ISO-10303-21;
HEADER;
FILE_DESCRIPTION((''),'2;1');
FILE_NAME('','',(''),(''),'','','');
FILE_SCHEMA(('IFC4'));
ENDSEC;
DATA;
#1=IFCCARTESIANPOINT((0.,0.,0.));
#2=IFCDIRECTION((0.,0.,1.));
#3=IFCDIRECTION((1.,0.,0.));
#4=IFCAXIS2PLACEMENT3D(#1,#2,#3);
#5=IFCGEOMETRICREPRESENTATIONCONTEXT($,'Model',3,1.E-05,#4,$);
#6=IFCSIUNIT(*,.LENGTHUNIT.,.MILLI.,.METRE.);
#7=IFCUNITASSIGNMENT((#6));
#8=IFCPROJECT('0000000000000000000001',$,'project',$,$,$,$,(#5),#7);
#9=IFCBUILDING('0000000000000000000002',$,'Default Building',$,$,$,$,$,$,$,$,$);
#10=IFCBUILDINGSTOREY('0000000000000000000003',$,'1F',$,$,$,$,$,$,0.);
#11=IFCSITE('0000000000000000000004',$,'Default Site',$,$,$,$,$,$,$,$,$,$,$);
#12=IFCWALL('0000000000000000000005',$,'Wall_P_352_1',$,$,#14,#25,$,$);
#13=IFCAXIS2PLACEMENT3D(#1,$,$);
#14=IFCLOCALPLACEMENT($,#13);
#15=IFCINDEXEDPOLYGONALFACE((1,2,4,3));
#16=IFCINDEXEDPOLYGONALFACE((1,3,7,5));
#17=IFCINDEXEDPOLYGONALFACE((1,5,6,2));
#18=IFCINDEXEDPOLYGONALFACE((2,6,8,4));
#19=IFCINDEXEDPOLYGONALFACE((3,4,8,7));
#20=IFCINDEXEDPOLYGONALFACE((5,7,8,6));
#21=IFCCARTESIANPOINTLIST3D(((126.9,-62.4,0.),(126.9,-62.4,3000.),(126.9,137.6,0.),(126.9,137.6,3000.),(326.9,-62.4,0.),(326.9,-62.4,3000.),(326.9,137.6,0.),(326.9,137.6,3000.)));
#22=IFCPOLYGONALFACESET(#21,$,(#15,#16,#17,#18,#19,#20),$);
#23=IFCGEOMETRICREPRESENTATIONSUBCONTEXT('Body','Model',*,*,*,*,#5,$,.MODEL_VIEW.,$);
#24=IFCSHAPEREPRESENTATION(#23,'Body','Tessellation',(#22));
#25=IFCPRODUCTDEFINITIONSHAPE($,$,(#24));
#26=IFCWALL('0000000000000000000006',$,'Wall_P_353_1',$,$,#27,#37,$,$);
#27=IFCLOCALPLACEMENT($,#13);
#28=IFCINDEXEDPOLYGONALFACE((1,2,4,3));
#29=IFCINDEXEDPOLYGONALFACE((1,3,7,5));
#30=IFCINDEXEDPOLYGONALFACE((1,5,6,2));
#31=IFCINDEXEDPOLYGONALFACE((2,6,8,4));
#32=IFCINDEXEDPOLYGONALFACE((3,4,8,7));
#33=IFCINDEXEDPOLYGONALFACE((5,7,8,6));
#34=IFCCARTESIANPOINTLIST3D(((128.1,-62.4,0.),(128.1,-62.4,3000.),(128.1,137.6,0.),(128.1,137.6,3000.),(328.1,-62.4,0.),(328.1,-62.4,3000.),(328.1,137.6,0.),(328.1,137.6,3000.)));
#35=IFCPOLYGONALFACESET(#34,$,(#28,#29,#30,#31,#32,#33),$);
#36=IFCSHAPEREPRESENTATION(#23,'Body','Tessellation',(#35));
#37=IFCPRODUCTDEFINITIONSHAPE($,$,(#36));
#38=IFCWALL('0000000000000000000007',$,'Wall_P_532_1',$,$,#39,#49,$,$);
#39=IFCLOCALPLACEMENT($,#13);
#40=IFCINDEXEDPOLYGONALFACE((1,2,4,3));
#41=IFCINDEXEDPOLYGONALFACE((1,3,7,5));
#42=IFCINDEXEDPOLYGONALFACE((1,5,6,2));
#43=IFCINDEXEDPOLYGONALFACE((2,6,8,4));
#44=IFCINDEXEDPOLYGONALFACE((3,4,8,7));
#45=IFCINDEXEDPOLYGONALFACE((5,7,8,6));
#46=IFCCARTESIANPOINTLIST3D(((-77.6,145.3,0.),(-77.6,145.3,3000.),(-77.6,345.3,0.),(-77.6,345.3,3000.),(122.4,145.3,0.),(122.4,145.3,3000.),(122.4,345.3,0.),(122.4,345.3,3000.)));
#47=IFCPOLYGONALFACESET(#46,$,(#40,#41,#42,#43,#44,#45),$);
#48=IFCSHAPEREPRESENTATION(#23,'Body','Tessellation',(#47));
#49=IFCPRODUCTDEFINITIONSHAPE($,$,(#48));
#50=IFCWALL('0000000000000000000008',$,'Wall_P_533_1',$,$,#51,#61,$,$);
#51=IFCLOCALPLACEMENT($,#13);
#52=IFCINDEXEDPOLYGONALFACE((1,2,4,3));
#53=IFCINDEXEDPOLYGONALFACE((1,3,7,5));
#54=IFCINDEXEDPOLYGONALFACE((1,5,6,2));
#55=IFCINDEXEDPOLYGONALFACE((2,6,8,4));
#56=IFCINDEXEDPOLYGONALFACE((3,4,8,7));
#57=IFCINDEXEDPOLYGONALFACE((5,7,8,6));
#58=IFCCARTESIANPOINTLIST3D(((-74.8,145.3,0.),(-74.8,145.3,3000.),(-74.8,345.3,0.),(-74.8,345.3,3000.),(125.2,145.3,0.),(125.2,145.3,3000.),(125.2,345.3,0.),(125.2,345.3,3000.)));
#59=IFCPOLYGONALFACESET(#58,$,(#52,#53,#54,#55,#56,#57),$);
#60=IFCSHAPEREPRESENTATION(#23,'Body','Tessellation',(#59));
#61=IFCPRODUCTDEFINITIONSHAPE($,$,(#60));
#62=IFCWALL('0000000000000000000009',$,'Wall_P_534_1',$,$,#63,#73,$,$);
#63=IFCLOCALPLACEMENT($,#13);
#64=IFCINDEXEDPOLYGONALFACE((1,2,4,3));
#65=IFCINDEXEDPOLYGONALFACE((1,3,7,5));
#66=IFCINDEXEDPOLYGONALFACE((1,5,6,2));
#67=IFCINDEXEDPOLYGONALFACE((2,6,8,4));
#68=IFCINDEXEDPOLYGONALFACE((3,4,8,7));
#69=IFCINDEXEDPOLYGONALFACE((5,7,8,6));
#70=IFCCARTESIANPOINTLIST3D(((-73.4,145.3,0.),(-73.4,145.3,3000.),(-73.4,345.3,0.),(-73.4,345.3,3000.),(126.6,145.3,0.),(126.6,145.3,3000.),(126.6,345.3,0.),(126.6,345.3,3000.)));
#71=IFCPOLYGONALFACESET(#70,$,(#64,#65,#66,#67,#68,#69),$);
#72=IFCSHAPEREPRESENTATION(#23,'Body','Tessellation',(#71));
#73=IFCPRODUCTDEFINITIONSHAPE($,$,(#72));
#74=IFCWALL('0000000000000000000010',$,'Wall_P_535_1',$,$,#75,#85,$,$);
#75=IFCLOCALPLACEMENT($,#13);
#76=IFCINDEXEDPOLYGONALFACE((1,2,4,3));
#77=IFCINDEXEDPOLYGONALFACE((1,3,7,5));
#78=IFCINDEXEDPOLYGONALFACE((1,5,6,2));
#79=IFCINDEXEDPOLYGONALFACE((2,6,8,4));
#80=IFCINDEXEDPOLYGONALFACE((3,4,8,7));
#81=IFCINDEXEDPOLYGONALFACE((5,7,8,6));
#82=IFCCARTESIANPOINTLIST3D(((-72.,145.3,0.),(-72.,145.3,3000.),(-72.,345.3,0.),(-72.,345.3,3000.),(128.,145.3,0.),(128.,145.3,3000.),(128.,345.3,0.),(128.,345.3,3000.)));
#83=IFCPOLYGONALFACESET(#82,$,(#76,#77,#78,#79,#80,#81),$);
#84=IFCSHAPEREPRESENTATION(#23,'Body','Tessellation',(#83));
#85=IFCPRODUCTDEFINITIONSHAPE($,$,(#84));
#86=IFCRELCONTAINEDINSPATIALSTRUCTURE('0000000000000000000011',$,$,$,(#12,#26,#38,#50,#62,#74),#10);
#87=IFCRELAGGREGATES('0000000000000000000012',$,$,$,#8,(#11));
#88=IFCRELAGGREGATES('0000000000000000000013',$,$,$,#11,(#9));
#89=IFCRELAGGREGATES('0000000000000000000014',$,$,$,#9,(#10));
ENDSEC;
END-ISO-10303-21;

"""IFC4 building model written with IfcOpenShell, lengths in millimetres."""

from ifc_helpers import new_model, si_unit, frame, origin_with_axes, place, context, subcontext, project, spatial, indexed_curve, outline, extrude, element, save


model = new_model("IFC4")

# Units and contexts
model_context = context("Model", 3, precision=1e-05, world=origin_with_axes())
body_context = subcontext(model_context, "Body", "Model", "MODEL_VIEW")
ifc_project = project(units=[si_unit("LENGTHUNIT", "METRE", prefix="MILLI")], contexts=[model_context])

# Site, building, storey
site = spatial("IfcSite", under=ifc_project, Name="Default Site")
building = spatial("IfcBuilding", under=site, Name="Default Building")
storey = spatial("IfcBuildingStorey", under=building, Name="1F", Elevation=0.0)

# Walls
for number, where, z_axis, x_axis, name in (
    (1, (126.9, 137.6, 0.0), (0.0, 0.0, 1.0), (0.0, -1.0, 0.0), "Wall_P_352_1"),
    (2, (128.1, 137.6, 0.0), (0.0, 0.0, 1.0), (0.0, -1.0, 0.0), "Wall_P_353_1"),
):
    element("IfcWall", number, at=place(None, frame(where, z_axis=z_axis, x_axis=x_axis)), inside=storey, Name=name, context=body_context, shape_type="SweptSolid", body=[
        extrude(outline(indexed_curve([(0.0, 0.0), (0.0, 200.0), (200.0, 200.0), (200.0, 0.0), (0.0, 0.0)], self_intersect=False)), origin_with_axes(), (0.0, 0.0, 1.0), 3000.0),
    ])
wall_1_placement = place(None, frame((122.4, 145.3, 0.0), z_axis=(0.0, 0.0, 1.0), x_axis=(0.0, 1.0, 0.0)))
element("IfcWall", 3, at=wall_1_placement, inside=storey, Name="Wall_P_532_1", context=body_context, shape_type="SweptSolid", body=[
    extrude(outline(indexed_curve([(0.0, 0.0), (0.0, 200.0), (200.0, 200.0), (200.0, 0.0), (0.0, 0.0)], self_intersect=False)), origin_with_axes(), (0.0, 0.0, 1.0), 3000.0),
])
wall_2_placement = place(None, frame((125.2, 145.3, 0.0), z_axis=(0.0, 0.0, 1.0), x_axis=(0.0, 1.0, 0.0)))
element("IfcWall", 4, at=wall_2_placement, inside=storey, Name="Wall_P_533_1", context=body_context, shape_type="SweptSolid", body=[
    extrude(outline(indexed_curve([(0.0, 0.0), (0.0, 200.0), (200.0, 200.0), (200.0, 0.0), (0.0, 0.0)], self_intersect=False)), origin_with_axes(), (0.0, 0.0, 1.0), 3000.0),
])
wall_3_placement = place(None, frame((126.6, 145.3, 0.0), z_axis=(0.0, 0.0, 1.0), x_axis=(0.0, 1.0, 0.0)))
element("IfcWall", 5, at=wall_3_placement, inside=storey, Name="Wall_P_534_1", context=body_context, shape_type="SweptSolid", body=[
    extrude(outline(indexed_curve([(0.0, 0.0), (0.0, 200.0), (200.0, 200.0), (200.0, 0.0), (0.0, 0.0)], self_intersect=False)), origin_with_axes(), (0.0, 0.0, 1.0), 3000.0),
])
wall_4_placement = place(None, frame((128.0, 145.3, 0.0), z_axis=(0.0, 0.0, 1.0), x_axis=(0.0, 1.0, 0.0)))
element("IfcWall", 6, at=wall_4_placement, inside=storey, Name="Wall_P_535_1", context=body_context, shape_type="SweptSolid", body=[
    extrude(outline(indexed_curve([(0.0, 0.0), (0.0, 200.0), (200.0, 200.0), (200.0, 0.0), (0.0, 0.0)], self_intersect=False)), origin_with_axes(), (0.0, 0.0, 1.0), 3000.0),
])

save(model, "model.ifc")
